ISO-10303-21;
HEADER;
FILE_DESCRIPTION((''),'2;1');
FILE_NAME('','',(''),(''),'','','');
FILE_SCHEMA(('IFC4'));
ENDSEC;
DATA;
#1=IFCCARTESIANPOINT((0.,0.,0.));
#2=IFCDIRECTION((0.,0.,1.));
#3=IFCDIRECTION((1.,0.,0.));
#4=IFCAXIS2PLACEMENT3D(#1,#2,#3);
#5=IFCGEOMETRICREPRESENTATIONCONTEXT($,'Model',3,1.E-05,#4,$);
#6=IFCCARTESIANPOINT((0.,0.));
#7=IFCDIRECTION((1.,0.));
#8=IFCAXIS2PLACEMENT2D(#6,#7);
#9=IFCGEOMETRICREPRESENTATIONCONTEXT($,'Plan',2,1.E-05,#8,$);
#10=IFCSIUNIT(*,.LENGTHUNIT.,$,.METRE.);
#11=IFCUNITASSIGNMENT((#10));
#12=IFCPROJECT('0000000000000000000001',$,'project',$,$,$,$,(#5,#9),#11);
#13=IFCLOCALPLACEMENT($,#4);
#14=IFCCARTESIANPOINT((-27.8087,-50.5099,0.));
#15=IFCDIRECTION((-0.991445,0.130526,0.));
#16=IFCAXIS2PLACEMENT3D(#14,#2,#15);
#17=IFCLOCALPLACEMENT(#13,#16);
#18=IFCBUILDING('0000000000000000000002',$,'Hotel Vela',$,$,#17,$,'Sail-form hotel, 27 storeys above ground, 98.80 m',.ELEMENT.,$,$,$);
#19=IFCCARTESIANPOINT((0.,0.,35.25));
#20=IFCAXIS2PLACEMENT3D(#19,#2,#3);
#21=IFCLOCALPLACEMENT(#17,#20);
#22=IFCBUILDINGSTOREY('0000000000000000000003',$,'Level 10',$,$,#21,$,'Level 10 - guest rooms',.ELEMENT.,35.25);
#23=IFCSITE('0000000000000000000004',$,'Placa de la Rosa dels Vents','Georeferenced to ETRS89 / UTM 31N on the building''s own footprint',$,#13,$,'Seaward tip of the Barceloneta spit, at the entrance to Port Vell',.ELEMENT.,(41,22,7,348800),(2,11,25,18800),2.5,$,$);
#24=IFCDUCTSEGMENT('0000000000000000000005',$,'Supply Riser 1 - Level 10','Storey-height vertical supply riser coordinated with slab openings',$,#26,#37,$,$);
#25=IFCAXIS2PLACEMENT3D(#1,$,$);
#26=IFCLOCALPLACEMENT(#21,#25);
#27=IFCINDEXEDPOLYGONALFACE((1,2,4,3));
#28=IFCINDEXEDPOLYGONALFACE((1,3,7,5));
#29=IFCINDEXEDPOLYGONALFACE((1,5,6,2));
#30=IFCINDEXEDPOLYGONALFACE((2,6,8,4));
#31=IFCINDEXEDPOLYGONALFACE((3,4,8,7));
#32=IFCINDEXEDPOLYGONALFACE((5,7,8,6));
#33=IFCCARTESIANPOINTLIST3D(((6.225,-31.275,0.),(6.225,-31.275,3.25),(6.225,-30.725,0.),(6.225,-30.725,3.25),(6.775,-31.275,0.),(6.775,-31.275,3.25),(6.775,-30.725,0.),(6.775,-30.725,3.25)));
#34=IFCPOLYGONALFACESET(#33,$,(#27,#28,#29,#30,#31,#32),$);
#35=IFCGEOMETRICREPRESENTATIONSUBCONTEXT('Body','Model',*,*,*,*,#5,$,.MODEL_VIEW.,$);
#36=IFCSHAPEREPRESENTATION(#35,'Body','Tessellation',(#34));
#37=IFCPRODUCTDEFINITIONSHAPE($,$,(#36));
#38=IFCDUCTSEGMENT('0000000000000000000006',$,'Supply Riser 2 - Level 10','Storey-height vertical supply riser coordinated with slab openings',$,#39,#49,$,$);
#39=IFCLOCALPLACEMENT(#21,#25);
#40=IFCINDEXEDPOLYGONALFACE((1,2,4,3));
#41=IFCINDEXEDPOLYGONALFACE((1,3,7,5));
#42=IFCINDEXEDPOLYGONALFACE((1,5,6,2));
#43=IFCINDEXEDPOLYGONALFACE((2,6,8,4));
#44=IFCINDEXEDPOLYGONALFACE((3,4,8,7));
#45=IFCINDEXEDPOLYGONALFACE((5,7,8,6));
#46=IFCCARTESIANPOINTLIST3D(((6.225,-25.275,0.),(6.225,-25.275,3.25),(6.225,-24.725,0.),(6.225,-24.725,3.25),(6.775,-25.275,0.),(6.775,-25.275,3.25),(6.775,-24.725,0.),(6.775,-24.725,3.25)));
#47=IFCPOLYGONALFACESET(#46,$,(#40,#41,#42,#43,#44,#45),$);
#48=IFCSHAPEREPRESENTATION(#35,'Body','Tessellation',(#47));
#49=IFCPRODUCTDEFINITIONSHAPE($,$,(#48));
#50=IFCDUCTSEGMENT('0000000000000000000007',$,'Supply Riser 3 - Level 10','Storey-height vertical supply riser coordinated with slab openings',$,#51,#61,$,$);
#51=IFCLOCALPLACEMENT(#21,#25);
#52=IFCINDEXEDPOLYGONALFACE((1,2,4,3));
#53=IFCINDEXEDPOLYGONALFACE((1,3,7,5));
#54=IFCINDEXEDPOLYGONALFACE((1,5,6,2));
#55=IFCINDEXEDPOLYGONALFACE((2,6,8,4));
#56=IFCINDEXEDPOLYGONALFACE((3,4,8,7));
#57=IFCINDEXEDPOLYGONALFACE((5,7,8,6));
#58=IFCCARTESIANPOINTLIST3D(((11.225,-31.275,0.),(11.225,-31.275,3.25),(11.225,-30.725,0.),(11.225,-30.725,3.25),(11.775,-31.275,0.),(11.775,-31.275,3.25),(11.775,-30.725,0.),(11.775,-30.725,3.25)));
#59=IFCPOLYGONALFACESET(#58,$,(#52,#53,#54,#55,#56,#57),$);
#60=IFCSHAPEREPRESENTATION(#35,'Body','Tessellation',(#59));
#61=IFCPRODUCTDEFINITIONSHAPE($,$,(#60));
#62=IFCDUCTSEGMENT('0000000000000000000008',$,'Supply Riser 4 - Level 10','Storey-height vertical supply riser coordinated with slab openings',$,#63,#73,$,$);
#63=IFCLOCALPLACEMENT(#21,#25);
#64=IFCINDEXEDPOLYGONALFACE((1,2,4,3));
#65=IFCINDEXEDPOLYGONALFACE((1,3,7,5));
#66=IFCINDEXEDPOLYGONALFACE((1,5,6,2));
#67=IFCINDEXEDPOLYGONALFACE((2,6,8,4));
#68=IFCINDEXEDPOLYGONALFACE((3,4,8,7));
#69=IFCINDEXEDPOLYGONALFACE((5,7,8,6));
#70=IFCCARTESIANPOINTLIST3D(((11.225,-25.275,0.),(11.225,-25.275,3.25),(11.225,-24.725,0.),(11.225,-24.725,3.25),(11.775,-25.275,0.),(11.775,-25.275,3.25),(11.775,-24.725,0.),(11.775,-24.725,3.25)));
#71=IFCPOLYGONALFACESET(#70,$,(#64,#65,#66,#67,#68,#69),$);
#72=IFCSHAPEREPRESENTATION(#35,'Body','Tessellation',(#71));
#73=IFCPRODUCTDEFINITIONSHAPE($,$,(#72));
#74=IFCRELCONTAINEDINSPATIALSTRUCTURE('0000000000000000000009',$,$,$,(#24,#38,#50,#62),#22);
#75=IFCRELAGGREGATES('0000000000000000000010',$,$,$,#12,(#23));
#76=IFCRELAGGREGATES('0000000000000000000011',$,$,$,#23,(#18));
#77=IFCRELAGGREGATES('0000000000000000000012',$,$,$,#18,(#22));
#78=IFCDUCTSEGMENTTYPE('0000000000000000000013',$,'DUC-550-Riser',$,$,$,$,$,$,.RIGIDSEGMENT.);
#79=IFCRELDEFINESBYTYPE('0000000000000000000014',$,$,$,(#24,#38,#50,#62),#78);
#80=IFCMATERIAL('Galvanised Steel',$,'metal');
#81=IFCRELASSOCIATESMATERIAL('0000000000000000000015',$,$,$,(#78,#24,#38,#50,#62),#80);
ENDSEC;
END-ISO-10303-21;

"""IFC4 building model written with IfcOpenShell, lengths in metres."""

from ifc_helpers import new_model, si_unit, frame, origin_with_axes, origin_2d_with_axis, place, context, subcontext, project, spatial, line, indexed_curve, outline, extrude, material, type_object, element, save


model = new_model("IFC4")

# Units and contexts
model_context = context("Model", 3, precision=1e-05, world=origin_with_axes())
plan_context = context("Plan", 2, precision=1e-05, world=origin_2d_with_axis())
body_context = subcontext(model_context, "Body", "Model", "MODEL_VIEW")
ifc_project = project(units=[si_unit("LENGTHUNIT", "METRE")], contexts=[model_context, plan_context])

# Site, building, storey
site_placement = place(None, origin_with_axes())
site = spatial("IfcSite", under=ifc_project, at=site_placement, Name="Placa de la Rosa dels Vents", Description="Georeferenced to ETRS89 / UTM 31N on the building's own footprint", LongName="Seaward tip of the Barceloneta spit, at the entrance to Port Vell", CompositionType="ELEMENT", RefLatitude=(41, 22, 7, 348800), RefLongitude=(2, 11, 25, 18800), RefElevation=2.5)
building_placement = place(site_placement, frame((-27.8087, -50.5099, 0.0), z_axis=(0.0, 0.0, 1.0), x_axis=(-0.991445, 0.130526, 0.0)))
building = spatial("IfcBuilding", under=site, at=building_placement, Name="Hotel Vela", LongName="Sail-form hotel, 27 storeys above ground, 98.80 m", CompositionType="ELEMENT")
storey_placement = place(building_placement, frame((0.0, 0.0, 35.25), z_axis=(0.0, 0.0, 1.0), x_axis=(1.0, 0.0, 0.0)))
storey = spatial("IfcBuildingStorey", under=building, at=storey_placement, Name="Level 10", LongName="Level 10 - guest rooms", CompositionType="ELEMENT", Elevation=35.25)

# Duct segments
ifc_material = material(Name="Galvanised Steel", Category="metal")
duct_segment_type = type_object("IfcDuctSegmentType", Name="DUC-550-Riser", PredefinedType="RIGIDSEGMENT", material=ifc_material)
for number, where, z_axis, x_axis, name in (
    (1, (6.225, -31.275, 0.0), (0.0, 0.0, 1.0), (1.0, 0.0, 0.0), "Supply Riser 1 - Level 10"),
    (2, (6.225, -25.275, 0.0), (0.0, 0.0, 1.0), (1.0, 0.0, 0.0), "Supply Riser 2 - Level 10"),
    (3, (11.225, -31.275, 0.0), (0.0, 0.0, 1.0), (1.0, 0.0, 0.0), "Supply Riser 3 - Level 10"),
    (4, (11.225, -25.275, 0.0), (0.0, 0.0, 1.0), (1.0, 0.0, 0.0), "Supply Riser 4 - Level 10"),
):
    element("IfcDuctSegment", number, at=place(storey_placement, frame(where, z_axis=z_axis, x_axis=x_axis)), inside=storey, type_object=duct_segment_type, material=ifc_material, Name=name, Description="Storey-height vertical supply riser coordinated with slab openings", context=body_context, shape_type="SweptSolid", body=[
        extrude(outline(indexed_curve([(0.0, 0.0), (0.55, 0.0), (0.55, 0.55), (0.0, 0.55)], segments=[line(1, 2, 3, 4, 1)])), origin_with_axes(), (0.0, 0.0, 1.0), 3.25),
    ])

save(model, "model.ifc")
